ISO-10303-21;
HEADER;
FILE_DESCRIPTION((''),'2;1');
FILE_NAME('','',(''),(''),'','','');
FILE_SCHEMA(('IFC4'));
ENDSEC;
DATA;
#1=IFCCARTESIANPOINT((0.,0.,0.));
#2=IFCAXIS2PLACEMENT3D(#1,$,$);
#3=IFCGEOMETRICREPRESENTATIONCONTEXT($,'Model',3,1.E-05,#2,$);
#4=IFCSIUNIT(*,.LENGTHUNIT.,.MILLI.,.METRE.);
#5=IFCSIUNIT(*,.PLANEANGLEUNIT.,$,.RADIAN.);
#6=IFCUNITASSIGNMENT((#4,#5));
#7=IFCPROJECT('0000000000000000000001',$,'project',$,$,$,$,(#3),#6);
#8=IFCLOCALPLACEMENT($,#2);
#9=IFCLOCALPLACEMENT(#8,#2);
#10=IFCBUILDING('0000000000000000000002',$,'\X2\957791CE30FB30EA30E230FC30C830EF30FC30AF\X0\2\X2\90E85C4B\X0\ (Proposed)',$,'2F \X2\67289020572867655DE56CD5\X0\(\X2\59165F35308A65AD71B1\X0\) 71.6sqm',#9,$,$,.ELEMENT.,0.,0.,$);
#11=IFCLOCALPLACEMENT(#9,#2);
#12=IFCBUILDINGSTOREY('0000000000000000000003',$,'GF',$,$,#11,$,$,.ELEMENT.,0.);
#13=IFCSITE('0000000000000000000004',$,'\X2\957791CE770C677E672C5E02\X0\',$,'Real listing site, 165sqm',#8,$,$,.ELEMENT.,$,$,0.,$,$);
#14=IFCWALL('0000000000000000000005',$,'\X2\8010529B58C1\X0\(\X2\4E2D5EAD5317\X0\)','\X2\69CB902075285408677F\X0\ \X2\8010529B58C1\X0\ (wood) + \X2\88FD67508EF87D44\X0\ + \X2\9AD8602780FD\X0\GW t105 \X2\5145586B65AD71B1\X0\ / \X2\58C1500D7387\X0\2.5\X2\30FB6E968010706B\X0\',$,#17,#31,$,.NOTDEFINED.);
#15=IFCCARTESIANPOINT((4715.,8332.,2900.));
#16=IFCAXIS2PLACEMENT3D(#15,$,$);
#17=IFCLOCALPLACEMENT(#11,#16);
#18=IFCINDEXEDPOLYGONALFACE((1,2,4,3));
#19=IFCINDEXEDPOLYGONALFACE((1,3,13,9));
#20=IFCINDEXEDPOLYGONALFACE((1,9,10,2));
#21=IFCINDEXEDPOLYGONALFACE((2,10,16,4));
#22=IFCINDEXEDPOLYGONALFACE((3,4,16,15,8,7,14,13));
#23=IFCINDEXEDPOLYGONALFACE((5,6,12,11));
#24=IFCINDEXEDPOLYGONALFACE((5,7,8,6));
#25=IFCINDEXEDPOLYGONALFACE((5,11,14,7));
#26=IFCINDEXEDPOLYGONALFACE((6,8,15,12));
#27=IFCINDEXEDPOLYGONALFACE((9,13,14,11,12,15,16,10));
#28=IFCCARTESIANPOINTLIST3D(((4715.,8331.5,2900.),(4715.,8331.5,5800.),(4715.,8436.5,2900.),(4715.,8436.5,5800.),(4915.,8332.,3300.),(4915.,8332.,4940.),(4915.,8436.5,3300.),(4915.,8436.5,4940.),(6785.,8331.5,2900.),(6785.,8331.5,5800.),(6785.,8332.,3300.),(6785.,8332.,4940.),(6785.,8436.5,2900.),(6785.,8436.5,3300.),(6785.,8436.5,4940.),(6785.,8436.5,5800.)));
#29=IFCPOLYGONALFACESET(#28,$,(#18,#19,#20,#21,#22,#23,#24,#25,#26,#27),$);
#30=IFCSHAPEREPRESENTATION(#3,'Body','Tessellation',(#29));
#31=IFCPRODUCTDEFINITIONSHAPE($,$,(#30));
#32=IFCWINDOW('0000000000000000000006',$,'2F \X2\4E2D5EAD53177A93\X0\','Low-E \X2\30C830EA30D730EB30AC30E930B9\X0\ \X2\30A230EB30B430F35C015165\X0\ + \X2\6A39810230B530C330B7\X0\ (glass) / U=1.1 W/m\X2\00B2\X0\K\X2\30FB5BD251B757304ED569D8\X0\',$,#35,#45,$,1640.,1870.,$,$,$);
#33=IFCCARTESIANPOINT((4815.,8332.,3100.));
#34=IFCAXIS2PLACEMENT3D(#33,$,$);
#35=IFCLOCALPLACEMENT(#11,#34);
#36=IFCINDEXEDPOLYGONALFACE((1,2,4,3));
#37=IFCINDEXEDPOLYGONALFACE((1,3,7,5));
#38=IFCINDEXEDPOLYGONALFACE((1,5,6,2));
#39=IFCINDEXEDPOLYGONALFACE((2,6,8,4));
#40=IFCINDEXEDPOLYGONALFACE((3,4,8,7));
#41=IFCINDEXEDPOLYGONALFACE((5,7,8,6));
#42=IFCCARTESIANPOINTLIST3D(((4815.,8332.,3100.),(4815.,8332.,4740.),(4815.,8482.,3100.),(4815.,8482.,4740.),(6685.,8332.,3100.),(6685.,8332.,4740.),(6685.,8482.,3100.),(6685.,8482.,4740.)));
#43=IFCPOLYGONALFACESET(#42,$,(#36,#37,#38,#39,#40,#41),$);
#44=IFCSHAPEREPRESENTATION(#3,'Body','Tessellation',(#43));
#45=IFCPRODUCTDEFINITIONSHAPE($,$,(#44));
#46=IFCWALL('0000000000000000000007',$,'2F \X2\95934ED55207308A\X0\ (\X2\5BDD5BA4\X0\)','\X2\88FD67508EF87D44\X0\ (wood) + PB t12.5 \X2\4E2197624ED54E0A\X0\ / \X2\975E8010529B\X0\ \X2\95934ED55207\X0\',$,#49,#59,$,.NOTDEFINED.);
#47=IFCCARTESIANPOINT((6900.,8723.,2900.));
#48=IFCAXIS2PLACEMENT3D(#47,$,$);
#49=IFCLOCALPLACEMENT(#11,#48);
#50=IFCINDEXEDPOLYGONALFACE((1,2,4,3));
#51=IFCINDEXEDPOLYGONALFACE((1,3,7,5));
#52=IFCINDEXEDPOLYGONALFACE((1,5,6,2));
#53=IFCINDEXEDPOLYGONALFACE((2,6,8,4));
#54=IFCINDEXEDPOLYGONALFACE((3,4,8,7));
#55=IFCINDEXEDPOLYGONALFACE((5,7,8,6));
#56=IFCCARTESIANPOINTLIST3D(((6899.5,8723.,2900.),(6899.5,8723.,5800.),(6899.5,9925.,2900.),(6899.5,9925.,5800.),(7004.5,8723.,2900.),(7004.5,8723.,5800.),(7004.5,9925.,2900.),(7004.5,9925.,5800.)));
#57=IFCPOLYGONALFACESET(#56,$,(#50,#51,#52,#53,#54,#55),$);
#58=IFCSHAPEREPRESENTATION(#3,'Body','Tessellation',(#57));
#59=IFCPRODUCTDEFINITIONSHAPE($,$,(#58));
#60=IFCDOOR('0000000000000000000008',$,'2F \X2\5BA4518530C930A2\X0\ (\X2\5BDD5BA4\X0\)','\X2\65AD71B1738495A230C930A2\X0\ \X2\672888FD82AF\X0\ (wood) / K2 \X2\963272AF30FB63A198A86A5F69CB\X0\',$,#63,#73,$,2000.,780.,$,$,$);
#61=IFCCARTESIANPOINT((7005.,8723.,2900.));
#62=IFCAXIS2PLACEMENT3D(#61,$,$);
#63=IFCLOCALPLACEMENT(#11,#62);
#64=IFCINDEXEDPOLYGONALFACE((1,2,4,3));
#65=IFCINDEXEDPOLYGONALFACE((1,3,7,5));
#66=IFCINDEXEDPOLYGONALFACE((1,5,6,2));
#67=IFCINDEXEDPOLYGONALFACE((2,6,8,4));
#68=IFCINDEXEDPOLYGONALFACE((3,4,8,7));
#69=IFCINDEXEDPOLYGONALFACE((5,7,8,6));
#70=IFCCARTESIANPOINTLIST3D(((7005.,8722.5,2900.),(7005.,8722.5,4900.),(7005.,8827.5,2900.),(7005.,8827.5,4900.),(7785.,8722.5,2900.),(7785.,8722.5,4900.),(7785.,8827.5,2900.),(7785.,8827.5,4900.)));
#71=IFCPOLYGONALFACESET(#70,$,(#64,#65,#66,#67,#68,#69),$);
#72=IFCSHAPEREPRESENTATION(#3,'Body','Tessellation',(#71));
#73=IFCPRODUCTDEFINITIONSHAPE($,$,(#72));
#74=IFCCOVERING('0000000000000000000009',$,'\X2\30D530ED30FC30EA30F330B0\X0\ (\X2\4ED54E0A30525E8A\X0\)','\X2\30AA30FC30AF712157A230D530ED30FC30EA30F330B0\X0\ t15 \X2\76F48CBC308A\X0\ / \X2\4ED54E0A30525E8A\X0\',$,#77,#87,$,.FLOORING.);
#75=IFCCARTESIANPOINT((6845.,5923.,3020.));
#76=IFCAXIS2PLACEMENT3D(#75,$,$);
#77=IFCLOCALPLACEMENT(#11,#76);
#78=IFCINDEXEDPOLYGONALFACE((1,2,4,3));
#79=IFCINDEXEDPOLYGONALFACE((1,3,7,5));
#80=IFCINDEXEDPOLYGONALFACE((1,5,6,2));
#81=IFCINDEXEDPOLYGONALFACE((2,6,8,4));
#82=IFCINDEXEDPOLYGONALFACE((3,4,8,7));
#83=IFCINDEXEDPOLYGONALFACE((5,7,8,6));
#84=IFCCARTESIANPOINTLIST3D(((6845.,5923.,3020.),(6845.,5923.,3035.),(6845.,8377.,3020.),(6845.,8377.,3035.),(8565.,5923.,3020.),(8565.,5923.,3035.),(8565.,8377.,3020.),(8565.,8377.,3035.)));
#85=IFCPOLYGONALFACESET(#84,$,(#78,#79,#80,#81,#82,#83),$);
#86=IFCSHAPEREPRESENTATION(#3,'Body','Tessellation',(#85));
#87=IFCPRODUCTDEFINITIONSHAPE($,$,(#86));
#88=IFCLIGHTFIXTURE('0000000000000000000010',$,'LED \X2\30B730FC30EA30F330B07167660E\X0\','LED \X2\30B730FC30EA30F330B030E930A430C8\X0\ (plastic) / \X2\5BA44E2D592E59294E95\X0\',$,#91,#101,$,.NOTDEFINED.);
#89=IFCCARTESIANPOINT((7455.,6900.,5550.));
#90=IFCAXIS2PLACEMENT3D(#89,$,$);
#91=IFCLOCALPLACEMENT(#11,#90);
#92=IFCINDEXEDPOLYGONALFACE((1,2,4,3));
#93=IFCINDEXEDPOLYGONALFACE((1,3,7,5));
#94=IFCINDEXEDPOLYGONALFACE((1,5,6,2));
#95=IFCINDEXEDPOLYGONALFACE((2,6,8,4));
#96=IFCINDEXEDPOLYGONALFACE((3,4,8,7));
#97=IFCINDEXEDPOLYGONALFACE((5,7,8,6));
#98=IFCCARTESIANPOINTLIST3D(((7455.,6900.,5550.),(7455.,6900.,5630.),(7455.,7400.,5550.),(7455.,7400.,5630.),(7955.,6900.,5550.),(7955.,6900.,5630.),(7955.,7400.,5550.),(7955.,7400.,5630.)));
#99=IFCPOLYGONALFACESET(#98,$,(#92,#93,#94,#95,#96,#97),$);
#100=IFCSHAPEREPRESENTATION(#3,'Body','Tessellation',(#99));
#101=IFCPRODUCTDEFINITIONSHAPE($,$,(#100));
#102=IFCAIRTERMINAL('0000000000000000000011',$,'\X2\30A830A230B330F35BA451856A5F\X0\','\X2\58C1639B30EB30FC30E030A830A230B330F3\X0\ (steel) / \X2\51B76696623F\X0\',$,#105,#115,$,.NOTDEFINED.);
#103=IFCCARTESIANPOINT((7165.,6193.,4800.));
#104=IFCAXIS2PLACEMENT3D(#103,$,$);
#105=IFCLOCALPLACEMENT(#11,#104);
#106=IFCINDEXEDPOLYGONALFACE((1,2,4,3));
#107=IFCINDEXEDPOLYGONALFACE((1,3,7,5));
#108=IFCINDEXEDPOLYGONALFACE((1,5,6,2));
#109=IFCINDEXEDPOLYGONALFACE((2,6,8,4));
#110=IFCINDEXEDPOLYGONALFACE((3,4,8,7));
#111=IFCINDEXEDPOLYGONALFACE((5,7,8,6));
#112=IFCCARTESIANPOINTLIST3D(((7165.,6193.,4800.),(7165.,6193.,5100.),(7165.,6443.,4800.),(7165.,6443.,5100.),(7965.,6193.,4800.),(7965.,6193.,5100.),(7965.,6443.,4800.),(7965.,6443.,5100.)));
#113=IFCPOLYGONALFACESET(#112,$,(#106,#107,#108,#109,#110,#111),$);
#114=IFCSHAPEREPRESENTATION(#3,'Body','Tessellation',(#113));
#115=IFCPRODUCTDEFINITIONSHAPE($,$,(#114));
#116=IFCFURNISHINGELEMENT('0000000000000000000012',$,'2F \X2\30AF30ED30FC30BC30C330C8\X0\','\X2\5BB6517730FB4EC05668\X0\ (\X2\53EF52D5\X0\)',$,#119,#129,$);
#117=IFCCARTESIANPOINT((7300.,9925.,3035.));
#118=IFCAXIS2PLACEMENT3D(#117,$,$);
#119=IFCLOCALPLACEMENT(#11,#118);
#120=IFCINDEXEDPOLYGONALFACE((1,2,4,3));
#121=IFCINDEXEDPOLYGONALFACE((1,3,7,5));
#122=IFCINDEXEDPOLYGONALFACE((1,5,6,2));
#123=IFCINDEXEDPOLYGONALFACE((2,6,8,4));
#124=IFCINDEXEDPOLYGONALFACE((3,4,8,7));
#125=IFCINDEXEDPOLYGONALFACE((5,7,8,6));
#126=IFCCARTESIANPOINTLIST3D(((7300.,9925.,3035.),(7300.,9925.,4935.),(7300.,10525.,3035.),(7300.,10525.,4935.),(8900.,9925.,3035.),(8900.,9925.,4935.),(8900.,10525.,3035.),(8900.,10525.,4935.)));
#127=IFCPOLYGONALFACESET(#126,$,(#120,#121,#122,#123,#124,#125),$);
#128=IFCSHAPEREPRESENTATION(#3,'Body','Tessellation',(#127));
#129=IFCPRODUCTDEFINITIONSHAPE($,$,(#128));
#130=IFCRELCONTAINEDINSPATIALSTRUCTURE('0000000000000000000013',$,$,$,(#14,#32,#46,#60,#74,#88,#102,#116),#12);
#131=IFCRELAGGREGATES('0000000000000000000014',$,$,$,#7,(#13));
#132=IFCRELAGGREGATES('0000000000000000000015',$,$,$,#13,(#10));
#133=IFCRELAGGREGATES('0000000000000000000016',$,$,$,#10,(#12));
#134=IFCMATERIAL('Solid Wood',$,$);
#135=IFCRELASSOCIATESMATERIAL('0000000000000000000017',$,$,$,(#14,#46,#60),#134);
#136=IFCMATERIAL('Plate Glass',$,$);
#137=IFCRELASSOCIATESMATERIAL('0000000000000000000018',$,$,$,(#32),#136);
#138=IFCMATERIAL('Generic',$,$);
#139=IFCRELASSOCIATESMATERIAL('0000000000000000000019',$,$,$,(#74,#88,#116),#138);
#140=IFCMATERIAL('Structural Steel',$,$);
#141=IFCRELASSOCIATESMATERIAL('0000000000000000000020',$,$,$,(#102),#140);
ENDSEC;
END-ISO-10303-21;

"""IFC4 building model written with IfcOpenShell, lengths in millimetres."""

from ifc_helpers import new_model, si_unit, frame, frame_2d, origin, place, context, project, spatial, rectangle, extrude, material, element, fill, save


model = new_model("IFC4")

# Units and contexts
model_context = context("Model", 3, precision=1e-05, world=origin())
ifc_project = project(units=[si_unit("LENGTHUNIT", "METRE", prefix="MILLI"), si_unit("PLANEANGLEUNIT", "RADIAN")], contexts=[model_context])

# Site, building, storey
site_placement = place(None, origin())
site = spatial("IfcSite", under=ifc_project, at=site_placement, Name="長野県松本市", ObjectType="Real listing site, 165sqm", CompositionType="ELEMENT", RefElevation=0.0)
building_placement = place(site_placement, origin())
building = spatial("IfcBuilding", under=site, at=building_placement, Name="長野・リモートワーク2部屋 (Proposed)", ObjectType="2F 木造在来工法(外張り断熱) 71.6sqm", CompositionType="ELEMENT", ElevationOfRefHeight=0.0, ElevationOfTerrain=0.0)
storey_placement = place(building_placement, origin())
storey = spatial("IfcBuildingStorey", under=building, at=storey_placement, Name="GF", CompositionType="ELEMENT", Elevation=0.0)

# Shared definitions
ifc_material_1 = material(Name="Solid Wood")

# Wall, opening, window
wall_1_placement = place(storey_placement, frame((4715.0, 8332.0, 2900.0)))
wall_1 = element("IfcWall", 1, at=wall_1_placement, inside=storey, material=ifc_material_1, Name="耐力壁(中庭北)", Description="構造用合板 耐力壁 (wood) + 製材軸組 + 高性能GW t105 充填断熱 / 壁倍率2.5・準耐火", PredefinedType="NOTDEFINED", context=model_context, shape_type="SweptSolid", body=[
    extrude(rectangle(XDim=2070.0, YDim=105.0, at=frame_2d((1035.0, 52.0))), frame((4715.0, 8332.0, 2900.0)), (0.0, 0.0, 1.0), 2900.0),
])
opening_placement = place(storey_placement, frame((4815.0, 8332.0, 3100.0)))
opening = element("IfcOpeningElement", 2, at=opening_placement, cuts=wall_1, PredefinedType="NOTDEFINED", context=model_context, shape_type="SweptSolid", body=[
    extrude(rectangle(XDim=1870.0, YDim=150.0, at=frame_2d((935.0, 75.0))), frame((4815.0, 8332.0, 3100.0)), (0.0, 0.0, 1.0), 1640.0),
])
ifc_material_2 = material(Name="Plate Glass")
window_placement = place(storey_placement, frame((4815.0, 8332.0, 3100.0)))
window = element("IfcWindow", 3, at=window_placement, inside=storey, material=ifc_material_2, Name="2F 中庭北窓", Description="Low-E トリプルガラス アルゴン封入 + 樹脂サッシ (glass) / U=1.1 W/m²K・寒冷地仕様", OverallHeight=1640.0, OverallWidth=1870.0, context=model_context, shape_type="SweptSolid", body=[
    extrude(rectangle(XDim=1870.0, YDim=150.0, at=frame_2d((935.0, 75.0))), frame((4815.0, 8332.0, 3100.0)), (0.0, 0.0, 1.0), 1640.0),
])
fill(opening, window)

# Wall
wall_2_placement = place(storey_placement, frame((6900.0, 8723.0, 2900.0)))
element("IfcWall", 4, at=wall_2_placement, inside=storey, material=ifc_material_1, Name="2F 間仕切り (寝室)", Description="製材軸組 (wood) + PB t12.5 両面仕上 / 非耐力 間仕切", PredefinedType="NOTDEFINED", context=model_context, shape_type="SweptSolid", body=[
    extrude(rectangle(XDim=105.0, YDim=1202.0, at=frame_2d((52.0, 601.0))), frame((6900.0, 8723.0, 2900.0)), (0.0, 0.0, 1.0), 2900.0),
])

# Door
door_placement = place(storey_placement, frame((7005.0, 8723.0, 2900.0)))
element("IfcDoor", 5, at=door_placement, inside=storey, material=ifc_material_1, Name="2F 室内ドア (寝室)", Description="断熱玄関ドア 木製芯 (wood) / K2 防犯・採風機構", OverallHeight=2000.0, OverallWidth=780.0, context=model_context, shape_type="SweptSolid", body=[
    extrude(rectangle(XDim=780.0, YDim=105.0, at=frame_2d((390.0, 52.0))), frame((7005.0, 8723.0, 2900.0)), (0.0, 0.0, 1.0), 2000.0),
])

# Covering
ifc_material_3 = material(Name="Generic")
covering_placement = place(storey_placement, frame((6845.0, 5923.0, 3020.0)))
element("IfcCovering", 6, at=covering_placement, inside=storey, material=ifc_material_3, Name="フローリング (仕上げ床)", Description="オーク無垢フローリング t15 直貼り / 仕上げ床", PredefinedType="FLOORING", context=model_context, shape_type="SweptSolid", body=[
    extrude(rectangle(XDim=1720.0, YDim=2454.0, at=frame_2d((860.0, 1227.0))), frame((6845.0, 5923.0, 3020.0)), (0.0, 0.0, 1.0), 15.0),
])

# Light fixture
light_fixture_placement = place(storey_placement, frame((7455.0, 6900.0, 5550.0)))
element("IfcLightFixture", 7, at=light_fixture_placement, inside=storey, material=ifc_material_3, Name="LED シーリング照明", Description="LED シーリングライト (plastic) / 室中央天井", PredefinedType="NOTDEFINED", context=model_context, shape_type="SweptSolid", body=[
    extrude(rectangle(XDim=500.0, YDim=500.0, at=frame_2d((250.0, 250.0))), frame((7455.0, 6900.0, 5550.0)), (0.0, 0.0, 1.0), 80.0),
])

# Air terminal
ifc_material_4 = material(Name="Structural Steel")
air_terminal_placement = place(storey_placement, frame((7165.0, 6193.0, 4800.0)))
element("IfcAirTerminal", 8, at=air_terminal_placement, inside=storey, material=ifc_material_4, Name="エアコン室内機", Description="壁掛ルームエアコン (steel) / 冷暖房", PredefinedType="NOTDEFINED", context=model_context, shape_type="SweptSolid", body=[
    extrude(rectangle(XDim=800.0, YDim=250.0, at=frame_2d((400.0, 125.0))), frame((7165.0, 6193.0, 4800.0)), (0.0, 0.0, 1.0), 300.0),
])

# Furnishing element
furnishing_placement = place(storey_placement, frame((7300.0, 9925.0, 3035.0)))
element("IfcFurnishingElement", 9, at=furnishing_placement, inside=storey, material=ifc_material_3, Name="2F クローゼット", Description="家具・什器 (可動)", context=model_context, shape_type="SweptSolid", body=[
    extrude(rectangle(XDim=1600.0, YDim=600.0, at=frame_2d((800.0, 300.0))), frame((7300.0, 9925.0, 3035.0)), (0.0, 0.0, 1.0), 1900.0),
])

save(model, "model.ifc")
